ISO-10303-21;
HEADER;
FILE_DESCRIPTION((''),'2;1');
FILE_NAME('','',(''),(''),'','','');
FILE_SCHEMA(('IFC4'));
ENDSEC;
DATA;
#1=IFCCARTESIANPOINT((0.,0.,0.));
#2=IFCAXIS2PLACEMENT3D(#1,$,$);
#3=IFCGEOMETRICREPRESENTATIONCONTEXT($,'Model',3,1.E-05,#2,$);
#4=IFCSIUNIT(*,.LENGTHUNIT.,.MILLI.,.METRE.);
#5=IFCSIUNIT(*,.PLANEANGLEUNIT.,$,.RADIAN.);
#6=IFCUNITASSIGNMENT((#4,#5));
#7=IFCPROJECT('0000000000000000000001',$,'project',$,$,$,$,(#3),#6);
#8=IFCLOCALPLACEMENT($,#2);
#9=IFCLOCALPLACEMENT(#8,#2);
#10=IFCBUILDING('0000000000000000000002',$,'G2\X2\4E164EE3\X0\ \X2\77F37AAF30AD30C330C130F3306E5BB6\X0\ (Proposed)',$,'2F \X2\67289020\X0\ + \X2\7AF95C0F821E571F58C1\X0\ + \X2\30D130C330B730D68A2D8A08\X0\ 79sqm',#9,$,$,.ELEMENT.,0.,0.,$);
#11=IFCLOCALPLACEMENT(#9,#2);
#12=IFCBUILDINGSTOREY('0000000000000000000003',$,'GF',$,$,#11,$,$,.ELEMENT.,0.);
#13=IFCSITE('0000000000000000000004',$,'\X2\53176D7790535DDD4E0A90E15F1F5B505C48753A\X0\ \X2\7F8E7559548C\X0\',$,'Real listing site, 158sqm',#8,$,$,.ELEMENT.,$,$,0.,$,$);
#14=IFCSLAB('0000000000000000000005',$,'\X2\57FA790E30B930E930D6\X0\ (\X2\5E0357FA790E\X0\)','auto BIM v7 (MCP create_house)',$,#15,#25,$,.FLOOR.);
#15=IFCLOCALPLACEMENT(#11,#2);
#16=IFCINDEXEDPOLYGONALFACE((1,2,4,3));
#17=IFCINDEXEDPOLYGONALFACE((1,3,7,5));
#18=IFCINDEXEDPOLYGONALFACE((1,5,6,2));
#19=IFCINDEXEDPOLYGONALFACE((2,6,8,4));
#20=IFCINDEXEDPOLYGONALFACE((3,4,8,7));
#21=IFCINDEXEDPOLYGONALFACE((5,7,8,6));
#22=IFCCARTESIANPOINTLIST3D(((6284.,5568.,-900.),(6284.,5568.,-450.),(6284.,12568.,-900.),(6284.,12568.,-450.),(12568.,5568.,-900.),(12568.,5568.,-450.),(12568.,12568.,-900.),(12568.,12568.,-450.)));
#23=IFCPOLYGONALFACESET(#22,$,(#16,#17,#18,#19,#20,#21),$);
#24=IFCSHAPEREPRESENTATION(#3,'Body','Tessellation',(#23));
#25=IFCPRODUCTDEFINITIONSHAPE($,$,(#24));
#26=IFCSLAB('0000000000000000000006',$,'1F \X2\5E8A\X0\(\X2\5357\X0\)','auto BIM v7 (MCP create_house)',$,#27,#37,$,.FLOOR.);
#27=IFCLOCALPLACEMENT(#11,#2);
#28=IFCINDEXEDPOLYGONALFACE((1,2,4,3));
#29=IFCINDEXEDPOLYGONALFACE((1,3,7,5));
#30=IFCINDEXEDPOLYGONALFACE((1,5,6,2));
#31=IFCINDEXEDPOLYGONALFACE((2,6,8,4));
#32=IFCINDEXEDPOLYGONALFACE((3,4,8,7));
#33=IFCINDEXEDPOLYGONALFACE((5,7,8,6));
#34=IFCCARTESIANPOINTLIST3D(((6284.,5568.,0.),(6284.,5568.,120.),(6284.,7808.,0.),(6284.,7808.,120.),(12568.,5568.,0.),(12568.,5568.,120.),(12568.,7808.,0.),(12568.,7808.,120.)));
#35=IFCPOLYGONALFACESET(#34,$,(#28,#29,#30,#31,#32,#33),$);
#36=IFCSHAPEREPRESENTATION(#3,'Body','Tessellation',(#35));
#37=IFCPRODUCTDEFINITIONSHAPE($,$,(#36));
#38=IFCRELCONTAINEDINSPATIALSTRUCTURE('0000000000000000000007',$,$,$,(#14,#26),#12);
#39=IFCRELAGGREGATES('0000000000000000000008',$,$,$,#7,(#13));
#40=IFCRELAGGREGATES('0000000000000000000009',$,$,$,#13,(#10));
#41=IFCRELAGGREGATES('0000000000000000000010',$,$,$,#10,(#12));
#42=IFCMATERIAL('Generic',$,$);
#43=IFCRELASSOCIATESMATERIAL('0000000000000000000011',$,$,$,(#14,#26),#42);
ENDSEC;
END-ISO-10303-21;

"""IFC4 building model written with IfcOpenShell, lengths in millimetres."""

from ifc_helpers import new_model, si_unit, frame, frame_2d, origin, place, context, project, spatial, rectangle, extrude, material, element, save


model = new_model("IFC4")

# Units and contexts
model_context = context("Model", 3, precision=1e-05, world=origin())
ifc_project = project(units=[si_unit("LENGTHUNIT", "METRE", prefix="MILLI"), si_unit("PLANEANGLEUNIT", "RADIAN")], contexts=[model_context])

# Site, building, storey
site_placement = place(None, origin())
site = spatial("IfcSite", under=ifc_project, at=site_placement, Name="北海道川上郡弟子屈町 美留和", ObjectType="Real listing site, 158sqm", CompositionType="ELEMENT", RefElevation=0.0)
building_placement = place(site_placement, origin())
building = spatial("IfcBuilding", under=site, at=building_placement, Name="G2世代 石窯キッチンの家 (Proposed)", ObjectType="2F 木造 + 竹小舞土壁 + パッシブ設計 79sqm", CompositionType="ELEMENT", ElevationOfRefHeight=0.0, ElevationOfTerrain=0.0)
storey_placement = place(building_placement, origin())
storey = spatial("IfcBuildingStorey", under=building, at=storey_placement, Name="GF", CompositionType="ELEMENT", Elevation=0.0)

# Slabs
ifc_material = material(Name="Generic")
slab_1_placement = place(storey_placement, frame((3142.0, 2784.0, -450.0)))
element("IfcSlab", 1, at=slab_1_placement, inside=storey, material=ifc_material, Name="基礎スラブ (布基礎)", Description="auto BIM v7 (MCP create_house)", PredefinedType="FLOOR", context=model_context, shape_type="SweptSolid", body=[
    extrude(rectangle(XDim=6284.0, YDim=7000.0, at=frame_2d((3142.0, 3500.0))), frame((3142.0, 2784.0, -450.0)), (0.0, 0.0, 1.0), 450.0),
])
slab_2_placement = place(storey_placement, frame((3142.0, 2784.0, 0.0)))
element("IfcSlab", 2, at=slab_2_placement, inside=storey, material=ifc_material, Name="1F 床(南)", Description="auto BIM v7 (MCP create_house)", PredefinedType="FLOOR", context=model_context, shape_type="SweptSolid", body=[
    extrude(rectangle(XDim=6284.0, YDim=2240.0, at=frame_2d((3142.0, 1120.0))), frame((3142.0, 2784.0, 0.0)), (0.0, 0.0, 1.0), 120.0),
])

save(model, "model.ifc")
